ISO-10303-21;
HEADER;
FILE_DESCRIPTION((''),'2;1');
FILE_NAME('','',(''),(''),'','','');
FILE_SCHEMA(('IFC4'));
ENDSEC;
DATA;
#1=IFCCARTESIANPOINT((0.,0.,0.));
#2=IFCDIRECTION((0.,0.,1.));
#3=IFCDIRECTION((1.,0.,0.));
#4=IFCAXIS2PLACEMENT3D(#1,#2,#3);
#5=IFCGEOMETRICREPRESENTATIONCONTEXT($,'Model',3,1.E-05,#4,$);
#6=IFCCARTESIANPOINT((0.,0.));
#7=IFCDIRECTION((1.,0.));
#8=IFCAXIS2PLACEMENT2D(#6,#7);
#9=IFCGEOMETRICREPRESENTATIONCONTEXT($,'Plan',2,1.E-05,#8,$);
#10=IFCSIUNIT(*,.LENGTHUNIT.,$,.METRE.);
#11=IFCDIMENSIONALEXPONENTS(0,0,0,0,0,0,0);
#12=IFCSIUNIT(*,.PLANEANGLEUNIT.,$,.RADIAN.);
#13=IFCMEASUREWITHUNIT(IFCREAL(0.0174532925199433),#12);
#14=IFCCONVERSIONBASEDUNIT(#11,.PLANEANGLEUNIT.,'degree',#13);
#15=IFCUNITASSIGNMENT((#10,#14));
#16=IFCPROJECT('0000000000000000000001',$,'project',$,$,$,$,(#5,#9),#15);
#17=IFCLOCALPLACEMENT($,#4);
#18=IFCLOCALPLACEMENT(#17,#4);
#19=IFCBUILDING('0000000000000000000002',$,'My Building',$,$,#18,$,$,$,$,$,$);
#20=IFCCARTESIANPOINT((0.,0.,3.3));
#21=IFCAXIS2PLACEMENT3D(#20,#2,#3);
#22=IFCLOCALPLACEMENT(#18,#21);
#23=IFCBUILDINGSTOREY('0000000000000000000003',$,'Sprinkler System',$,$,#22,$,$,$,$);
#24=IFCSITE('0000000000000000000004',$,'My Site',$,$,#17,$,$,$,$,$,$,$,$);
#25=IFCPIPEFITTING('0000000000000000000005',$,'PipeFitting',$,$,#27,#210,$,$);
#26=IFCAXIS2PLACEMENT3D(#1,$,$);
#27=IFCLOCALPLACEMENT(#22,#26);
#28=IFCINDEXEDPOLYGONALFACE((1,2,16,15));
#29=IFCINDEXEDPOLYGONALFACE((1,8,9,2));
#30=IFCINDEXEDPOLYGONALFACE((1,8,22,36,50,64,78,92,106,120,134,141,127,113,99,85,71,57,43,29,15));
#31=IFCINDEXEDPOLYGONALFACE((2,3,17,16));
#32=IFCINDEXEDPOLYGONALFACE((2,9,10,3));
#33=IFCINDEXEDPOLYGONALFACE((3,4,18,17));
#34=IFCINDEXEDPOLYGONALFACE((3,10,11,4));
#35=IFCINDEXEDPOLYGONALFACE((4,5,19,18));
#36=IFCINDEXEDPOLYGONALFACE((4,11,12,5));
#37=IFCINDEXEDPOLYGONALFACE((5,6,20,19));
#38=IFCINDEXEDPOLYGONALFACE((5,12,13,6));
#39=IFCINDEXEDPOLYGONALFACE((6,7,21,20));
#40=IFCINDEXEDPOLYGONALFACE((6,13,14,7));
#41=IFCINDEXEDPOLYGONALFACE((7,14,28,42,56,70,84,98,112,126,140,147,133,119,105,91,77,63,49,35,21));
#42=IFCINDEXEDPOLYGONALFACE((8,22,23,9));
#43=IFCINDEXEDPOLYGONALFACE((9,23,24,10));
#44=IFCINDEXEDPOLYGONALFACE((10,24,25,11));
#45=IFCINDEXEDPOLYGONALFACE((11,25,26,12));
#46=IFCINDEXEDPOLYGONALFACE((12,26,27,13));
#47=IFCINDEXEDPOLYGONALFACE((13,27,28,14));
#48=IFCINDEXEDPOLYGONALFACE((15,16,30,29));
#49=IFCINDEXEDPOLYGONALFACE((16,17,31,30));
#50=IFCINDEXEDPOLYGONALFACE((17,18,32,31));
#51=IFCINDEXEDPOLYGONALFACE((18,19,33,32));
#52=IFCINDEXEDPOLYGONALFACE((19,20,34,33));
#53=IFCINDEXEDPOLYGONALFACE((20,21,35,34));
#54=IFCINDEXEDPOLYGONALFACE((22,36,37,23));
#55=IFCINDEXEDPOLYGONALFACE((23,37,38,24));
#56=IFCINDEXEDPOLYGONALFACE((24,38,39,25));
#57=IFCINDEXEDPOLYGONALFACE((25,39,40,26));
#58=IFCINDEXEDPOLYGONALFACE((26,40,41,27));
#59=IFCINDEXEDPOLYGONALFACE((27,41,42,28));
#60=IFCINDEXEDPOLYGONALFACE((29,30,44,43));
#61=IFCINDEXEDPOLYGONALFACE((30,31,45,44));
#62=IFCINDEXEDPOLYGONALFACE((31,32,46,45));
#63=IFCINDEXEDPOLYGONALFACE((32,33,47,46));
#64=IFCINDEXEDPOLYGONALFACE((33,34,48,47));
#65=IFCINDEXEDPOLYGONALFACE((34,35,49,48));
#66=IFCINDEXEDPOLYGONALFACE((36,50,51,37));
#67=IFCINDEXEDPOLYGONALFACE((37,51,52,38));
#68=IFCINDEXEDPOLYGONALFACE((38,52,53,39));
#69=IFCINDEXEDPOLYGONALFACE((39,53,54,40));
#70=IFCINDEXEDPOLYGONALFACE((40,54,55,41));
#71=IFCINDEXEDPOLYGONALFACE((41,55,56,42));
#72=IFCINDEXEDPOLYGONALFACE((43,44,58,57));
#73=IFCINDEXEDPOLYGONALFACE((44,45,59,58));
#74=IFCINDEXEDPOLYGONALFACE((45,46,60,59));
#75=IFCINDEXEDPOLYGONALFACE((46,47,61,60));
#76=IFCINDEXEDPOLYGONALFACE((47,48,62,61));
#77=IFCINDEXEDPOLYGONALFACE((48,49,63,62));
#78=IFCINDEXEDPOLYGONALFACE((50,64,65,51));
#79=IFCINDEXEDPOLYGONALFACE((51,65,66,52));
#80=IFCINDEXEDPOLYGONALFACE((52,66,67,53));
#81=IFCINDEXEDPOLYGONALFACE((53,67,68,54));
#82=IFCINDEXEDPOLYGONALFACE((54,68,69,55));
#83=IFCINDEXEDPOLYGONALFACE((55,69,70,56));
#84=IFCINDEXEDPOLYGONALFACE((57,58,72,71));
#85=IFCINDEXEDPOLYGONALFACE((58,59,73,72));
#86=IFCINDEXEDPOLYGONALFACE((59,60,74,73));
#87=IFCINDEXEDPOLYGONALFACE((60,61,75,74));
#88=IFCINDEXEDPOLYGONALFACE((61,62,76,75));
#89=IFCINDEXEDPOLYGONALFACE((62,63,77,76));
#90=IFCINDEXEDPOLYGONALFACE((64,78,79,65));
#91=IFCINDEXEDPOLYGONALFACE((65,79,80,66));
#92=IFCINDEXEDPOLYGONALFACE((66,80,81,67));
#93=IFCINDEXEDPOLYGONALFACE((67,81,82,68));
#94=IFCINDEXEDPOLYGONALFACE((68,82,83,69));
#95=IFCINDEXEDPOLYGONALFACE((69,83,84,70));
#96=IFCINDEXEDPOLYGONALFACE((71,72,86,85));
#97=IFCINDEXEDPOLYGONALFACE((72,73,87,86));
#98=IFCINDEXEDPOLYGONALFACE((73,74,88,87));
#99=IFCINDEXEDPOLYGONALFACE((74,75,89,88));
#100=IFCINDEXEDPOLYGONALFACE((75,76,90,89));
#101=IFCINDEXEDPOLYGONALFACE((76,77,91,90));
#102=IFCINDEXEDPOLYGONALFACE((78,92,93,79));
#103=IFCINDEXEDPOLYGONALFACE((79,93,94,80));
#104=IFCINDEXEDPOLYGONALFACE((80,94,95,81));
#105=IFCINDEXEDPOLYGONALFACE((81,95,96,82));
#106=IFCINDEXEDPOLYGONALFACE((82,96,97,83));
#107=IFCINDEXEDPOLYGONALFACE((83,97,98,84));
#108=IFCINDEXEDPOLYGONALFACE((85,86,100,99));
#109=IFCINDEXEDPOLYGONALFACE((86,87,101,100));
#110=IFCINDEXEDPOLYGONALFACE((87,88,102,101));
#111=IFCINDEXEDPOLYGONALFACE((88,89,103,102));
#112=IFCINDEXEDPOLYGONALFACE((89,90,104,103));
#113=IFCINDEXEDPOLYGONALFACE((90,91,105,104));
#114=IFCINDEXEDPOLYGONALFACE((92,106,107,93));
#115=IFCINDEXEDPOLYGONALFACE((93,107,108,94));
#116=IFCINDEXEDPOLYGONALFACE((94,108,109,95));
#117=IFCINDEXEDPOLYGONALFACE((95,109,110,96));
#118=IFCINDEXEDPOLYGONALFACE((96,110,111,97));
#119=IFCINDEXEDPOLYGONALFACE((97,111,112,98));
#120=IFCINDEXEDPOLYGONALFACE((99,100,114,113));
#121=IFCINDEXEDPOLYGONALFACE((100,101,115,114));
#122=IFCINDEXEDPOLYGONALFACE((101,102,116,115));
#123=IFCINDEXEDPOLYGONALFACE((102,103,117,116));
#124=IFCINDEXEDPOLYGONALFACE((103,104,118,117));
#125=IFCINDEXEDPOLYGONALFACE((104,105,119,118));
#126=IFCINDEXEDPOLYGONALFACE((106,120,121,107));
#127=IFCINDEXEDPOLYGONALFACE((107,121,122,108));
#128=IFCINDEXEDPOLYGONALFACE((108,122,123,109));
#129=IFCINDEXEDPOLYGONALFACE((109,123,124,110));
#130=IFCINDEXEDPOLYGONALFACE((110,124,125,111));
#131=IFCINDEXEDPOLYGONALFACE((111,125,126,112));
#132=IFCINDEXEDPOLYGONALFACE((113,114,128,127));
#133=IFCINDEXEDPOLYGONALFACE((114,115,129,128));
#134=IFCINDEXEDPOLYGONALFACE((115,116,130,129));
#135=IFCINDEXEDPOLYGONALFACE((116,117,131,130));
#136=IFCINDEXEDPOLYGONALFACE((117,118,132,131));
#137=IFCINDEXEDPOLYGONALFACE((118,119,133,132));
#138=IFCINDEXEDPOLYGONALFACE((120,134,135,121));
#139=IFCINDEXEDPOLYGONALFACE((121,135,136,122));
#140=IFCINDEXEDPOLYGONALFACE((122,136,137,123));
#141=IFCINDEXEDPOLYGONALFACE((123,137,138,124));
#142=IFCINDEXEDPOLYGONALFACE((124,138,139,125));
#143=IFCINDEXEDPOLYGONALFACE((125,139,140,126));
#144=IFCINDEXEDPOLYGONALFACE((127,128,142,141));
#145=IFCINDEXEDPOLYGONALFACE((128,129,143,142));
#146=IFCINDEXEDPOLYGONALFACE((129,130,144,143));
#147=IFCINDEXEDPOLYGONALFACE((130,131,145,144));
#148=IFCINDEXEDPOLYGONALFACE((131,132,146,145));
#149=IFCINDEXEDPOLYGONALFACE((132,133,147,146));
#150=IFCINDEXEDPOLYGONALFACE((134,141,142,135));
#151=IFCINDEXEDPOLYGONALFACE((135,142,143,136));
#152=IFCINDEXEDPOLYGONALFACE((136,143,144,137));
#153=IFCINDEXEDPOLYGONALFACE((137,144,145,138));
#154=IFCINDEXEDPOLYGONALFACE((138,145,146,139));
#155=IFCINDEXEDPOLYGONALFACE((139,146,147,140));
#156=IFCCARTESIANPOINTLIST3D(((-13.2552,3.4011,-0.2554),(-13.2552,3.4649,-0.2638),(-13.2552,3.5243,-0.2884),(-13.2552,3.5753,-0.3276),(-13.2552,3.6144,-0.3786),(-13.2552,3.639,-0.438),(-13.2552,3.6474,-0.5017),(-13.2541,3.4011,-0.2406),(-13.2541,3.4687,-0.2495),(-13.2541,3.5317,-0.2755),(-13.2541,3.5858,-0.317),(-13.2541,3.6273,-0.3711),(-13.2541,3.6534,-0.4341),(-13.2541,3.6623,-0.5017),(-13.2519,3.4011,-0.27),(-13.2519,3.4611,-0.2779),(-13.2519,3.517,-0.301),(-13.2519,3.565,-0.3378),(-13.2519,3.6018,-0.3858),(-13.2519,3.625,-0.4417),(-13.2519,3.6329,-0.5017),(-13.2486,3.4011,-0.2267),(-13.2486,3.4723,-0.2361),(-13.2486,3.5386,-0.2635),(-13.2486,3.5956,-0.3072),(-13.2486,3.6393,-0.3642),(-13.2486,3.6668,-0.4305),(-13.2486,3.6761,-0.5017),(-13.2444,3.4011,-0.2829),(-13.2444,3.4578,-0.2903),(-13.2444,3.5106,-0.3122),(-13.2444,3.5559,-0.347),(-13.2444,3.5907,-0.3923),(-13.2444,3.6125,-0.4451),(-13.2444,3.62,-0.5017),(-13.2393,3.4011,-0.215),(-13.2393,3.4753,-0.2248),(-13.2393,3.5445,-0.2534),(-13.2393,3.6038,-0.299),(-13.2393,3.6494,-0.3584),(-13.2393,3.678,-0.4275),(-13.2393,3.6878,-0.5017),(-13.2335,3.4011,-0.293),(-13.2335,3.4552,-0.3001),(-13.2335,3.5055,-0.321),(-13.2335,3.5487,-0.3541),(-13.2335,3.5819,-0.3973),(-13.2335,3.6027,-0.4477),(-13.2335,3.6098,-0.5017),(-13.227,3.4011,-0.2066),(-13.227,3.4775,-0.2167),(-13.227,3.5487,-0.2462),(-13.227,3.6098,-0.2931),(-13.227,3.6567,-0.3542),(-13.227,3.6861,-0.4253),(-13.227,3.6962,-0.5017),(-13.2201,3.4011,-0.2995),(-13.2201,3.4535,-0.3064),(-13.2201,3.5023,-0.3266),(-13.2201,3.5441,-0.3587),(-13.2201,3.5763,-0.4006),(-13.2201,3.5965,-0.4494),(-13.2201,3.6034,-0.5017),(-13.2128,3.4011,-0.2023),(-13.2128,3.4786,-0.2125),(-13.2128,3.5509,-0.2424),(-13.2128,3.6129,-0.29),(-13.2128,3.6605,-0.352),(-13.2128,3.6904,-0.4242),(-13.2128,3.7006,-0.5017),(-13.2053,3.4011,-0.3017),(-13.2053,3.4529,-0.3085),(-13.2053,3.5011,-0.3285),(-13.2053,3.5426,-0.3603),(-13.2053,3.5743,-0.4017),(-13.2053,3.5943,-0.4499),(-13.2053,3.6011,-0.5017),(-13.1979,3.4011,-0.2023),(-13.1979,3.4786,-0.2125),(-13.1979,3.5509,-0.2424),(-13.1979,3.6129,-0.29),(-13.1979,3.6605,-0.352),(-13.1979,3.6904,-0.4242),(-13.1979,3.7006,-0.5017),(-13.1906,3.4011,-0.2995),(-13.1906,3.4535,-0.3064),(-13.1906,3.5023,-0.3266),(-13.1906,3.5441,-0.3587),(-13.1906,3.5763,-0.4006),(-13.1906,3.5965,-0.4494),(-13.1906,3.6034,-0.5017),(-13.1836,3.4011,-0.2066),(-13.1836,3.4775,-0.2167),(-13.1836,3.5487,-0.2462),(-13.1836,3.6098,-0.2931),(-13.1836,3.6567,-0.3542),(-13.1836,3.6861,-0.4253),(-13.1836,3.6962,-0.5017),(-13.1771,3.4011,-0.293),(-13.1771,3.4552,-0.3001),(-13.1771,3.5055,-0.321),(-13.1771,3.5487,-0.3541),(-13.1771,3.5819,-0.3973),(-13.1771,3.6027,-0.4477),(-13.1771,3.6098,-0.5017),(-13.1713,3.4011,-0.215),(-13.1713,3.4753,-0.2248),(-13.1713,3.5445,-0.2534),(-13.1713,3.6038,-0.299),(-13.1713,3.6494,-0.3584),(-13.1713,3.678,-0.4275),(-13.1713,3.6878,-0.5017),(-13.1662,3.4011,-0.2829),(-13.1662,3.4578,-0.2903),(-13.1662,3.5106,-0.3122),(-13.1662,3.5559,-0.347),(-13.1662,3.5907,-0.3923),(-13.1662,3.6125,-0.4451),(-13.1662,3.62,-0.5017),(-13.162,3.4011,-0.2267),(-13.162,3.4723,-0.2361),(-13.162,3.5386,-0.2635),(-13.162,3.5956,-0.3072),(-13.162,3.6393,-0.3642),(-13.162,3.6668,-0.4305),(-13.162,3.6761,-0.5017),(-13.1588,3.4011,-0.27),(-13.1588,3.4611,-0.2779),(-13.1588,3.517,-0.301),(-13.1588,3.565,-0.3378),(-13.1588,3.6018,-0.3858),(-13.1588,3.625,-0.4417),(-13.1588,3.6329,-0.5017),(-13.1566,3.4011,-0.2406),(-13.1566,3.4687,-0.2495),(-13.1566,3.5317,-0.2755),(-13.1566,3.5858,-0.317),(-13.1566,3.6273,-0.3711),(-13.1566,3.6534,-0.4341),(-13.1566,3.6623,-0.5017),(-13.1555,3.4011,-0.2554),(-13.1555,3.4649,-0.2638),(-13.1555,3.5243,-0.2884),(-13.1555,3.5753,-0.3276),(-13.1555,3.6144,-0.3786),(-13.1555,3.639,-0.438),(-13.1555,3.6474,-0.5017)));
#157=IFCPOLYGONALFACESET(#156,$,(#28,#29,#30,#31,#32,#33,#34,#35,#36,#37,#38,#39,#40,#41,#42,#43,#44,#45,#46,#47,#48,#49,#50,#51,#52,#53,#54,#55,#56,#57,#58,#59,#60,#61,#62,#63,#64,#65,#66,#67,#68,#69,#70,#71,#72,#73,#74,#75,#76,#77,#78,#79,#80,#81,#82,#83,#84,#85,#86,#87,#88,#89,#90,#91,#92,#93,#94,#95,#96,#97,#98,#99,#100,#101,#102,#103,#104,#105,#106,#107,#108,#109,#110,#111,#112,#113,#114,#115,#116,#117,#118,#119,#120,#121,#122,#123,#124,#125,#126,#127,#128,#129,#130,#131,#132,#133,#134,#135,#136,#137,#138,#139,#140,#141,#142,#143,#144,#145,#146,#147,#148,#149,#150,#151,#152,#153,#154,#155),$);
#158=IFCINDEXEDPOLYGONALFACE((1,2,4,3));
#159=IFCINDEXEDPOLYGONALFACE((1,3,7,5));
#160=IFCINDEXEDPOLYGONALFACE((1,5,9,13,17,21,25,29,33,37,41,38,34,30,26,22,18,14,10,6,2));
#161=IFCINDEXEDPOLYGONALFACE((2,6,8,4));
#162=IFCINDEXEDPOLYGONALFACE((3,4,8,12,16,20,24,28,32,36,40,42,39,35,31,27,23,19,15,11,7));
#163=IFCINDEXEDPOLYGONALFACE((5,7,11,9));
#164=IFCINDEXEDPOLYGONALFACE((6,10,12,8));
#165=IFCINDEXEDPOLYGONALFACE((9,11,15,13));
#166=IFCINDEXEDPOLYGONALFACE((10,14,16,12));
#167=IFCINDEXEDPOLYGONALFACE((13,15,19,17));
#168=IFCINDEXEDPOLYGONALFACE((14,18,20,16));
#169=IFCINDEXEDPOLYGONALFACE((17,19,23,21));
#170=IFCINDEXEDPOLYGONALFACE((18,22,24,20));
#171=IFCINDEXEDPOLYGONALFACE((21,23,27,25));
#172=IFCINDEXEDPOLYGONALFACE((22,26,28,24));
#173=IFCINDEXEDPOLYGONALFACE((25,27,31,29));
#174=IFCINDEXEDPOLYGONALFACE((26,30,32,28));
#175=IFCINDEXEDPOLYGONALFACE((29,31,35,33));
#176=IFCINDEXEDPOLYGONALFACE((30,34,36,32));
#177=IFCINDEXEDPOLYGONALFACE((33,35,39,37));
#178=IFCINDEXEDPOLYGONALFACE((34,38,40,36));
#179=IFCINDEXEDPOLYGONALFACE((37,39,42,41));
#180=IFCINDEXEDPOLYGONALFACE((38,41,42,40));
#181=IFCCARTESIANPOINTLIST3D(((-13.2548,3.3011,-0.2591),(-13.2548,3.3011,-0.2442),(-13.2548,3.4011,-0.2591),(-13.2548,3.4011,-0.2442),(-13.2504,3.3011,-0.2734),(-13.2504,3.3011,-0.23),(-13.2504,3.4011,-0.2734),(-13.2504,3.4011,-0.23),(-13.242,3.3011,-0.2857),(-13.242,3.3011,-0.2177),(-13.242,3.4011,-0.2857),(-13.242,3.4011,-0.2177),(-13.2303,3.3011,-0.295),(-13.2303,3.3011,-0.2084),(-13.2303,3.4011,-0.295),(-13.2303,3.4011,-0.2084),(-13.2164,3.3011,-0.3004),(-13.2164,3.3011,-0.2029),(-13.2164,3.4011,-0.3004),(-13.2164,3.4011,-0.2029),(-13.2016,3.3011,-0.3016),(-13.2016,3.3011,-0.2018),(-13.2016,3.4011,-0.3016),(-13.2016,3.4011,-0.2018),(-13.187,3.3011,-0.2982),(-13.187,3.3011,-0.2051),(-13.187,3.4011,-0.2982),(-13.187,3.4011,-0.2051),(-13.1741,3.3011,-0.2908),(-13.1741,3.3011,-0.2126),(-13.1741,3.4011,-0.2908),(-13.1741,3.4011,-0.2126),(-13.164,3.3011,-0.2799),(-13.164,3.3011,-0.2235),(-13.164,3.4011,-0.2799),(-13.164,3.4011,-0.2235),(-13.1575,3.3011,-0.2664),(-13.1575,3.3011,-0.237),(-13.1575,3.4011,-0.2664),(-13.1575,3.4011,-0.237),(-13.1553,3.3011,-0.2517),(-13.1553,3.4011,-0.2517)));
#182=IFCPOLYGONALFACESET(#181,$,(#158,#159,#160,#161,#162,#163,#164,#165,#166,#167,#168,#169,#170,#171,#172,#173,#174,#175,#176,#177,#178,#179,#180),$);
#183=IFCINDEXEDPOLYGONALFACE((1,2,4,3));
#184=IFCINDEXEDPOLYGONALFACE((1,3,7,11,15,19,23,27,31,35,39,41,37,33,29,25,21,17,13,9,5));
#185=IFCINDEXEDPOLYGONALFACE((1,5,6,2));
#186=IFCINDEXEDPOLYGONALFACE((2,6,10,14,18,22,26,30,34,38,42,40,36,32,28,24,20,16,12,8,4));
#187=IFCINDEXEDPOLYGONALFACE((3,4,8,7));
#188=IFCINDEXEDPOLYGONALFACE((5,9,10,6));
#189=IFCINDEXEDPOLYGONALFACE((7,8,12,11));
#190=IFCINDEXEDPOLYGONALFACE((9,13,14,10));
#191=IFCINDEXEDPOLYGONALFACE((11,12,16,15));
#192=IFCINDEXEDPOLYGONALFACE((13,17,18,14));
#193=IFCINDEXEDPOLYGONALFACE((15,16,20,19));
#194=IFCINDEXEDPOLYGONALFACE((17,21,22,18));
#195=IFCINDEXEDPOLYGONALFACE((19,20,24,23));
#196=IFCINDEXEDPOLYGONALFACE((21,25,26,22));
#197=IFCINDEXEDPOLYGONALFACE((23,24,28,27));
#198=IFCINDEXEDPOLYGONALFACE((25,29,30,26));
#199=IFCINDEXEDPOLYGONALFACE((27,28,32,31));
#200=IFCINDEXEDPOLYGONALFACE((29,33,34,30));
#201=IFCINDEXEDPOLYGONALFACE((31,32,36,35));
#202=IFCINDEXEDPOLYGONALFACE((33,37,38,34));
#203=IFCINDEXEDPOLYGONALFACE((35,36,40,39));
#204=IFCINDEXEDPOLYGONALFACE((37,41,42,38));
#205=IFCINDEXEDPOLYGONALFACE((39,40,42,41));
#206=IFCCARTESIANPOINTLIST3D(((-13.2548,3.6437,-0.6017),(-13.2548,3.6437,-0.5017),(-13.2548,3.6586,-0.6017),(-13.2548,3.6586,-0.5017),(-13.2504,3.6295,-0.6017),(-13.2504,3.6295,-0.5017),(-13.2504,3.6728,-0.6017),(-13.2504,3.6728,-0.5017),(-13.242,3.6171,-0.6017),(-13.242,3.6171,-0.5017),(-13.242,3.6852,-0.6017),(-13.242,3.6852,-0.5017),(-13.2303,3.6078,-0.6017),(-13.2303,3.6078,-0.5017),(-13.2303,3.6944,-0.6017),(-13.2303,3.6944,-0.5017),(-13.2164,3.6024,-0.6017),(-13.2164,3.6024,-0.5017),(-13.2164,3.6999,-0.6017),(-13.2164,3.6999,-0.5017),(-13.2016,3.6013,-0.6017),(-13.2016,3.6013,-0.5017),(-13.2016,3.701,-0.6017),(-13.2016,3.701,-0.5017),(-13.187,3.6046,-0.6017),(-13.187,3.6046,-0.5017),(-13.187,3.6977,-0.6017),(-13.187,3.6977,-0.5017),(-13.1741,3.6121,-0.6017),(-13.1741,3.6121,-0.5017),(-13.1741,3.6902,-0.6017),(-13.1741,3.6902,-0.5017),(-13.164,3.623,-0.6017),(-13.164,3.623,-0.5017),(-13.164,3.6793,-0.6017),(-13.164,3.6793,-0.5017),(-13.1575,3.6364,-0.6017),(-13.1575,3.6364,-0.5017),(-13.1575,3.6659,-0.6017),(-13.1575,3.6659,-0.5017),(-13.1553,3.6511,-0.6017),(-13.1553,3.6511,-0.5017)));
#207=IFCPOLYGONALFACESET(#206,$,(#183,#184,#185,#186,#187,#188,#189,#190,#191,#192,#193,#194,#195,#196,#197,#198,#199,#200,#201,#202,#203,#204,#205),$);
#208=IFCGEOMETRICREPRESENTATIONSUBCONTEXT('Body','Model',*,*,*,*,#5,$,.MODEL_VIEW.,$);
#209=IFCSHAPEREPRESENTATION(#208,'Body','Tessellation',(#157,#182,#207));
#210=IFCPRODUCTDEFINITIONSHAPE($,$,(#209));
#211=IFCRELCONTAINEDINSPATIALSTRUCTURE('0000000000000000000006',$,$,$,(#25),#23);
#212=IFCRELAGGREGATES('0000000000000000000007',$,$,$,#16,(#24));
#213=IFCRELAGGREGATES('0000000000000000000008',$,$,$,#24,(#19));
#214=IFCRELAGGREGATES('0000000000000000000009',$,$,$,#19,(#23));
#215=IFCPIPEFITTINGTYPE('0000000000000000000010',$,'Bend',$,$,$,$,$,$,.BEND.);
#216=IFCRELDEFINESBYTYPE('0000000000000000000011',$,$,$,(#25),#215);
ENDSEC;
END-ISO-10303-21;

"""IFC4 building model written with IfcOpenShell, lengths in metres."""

from ifc_helpers import new_model, entity, si_unit, converted_unit, frame, origin_with_axes, origin_2d_with_axis, place, context, subcontext, project, spatial, circle, extrude, source, transform, mapped, type_object, type_shapes, element, save


model = new_model("IFC4")

# Units and contexts
model_context = context("Model", 3, precision=1e-05, world=origin_with_axes())
plan_context = context("Plan", 2, precision=1e-05, world=origin_2d_with_axis())
body_context = subcontext(model_context, "Body", "Model", "MODEL_VIEW")
ifc_project = project(units=[si_unit("LENGTHUNIT", "METRE"), converted_unit("PLANEANGLEUNIT", "degree", entity("IfcReal", 0.0174532925199433), si_unit("PLANEANGLEUNIT", "RADIAN"), dimensions=[0, 0, 0, 0, 0, 0, 0])], contexts=[model_context, plan_context])

# Site, building, storey
site_placement = place(None, origin_with_axes())
site = spatial("IfcSite", under=ifc_project, at=site_placement, Name="My Site")
building_placement = place(site_placement, origin_with_axes())
building = spatial("IfcBuilding", under=site, at=building_placement, Name="My Building")
storey_placement = place(building_placement, frame((0.0, 0.0, 3.3), z_axis=(0.0, 0.0, 1.0), x_axis=(1.0, 0.0, 0.0)))
storey = spatial("IfcBuildingStorey", under=building, at=storey_placement, Name="Sprinkler System")

# Pipe fitting
pipe_fitting_type_1 = type_object("IfcPipeFittingType", Name="Bend", PredefinedType="BEND")
shared_shape_1 = source(origin_with_axes(), body_context, "Body", "SolidModel", [
    entity("IfcSweptDiskSolid", entity("IfcIndexedPolyCurve", entity("IfcCartesianPointList3D", [[0.0, 0.0, -0.1], [0.0, -0.0732, -0.2768], [0.0, -0.25, -0.35]]), [entity("IfcArcIndex", [1, 2, 3])]), 0.05),
    extrude(circle(Radius=0.05), origin_with_axes(), (0.0, 0.0, -1.0), 0.1),
    extrude(circle(Radius=0.05), frame((0.0, -0.25, -0.35), z_axis=(0.0, -1.0, 0.000012), x_axis=(1.0, 0.0, 0.0)), (0.0, 0.0, 1.0), 0.1),
])
type_shapes(pipe_fitting_type_1, [shared_shape_1])
for number, where, z_axis, x_axis, name in (
    (1, (-13.2053, 3.3011, -0.2517), (-0.000001, -1.0, -0.000012), (1.0, -0.000001, 0.0), "PipeFitting"),
):
    element("IfcPipeFitting", number, at=place(storey_placement, frame(where, z_axis=z_axis, x_axis=x_axis)), inside=storey, type_object=pipe_fitting_type_1, Name=name, context=body_context, shape_type="MappedRepresentation", body=[
        mapped(shared_shape_1, transform((0.0, 0.0, 0.0), x_axis=(1.0, 0.0, 0.0), y_axis=(0.0, 1.0, 0.0), z_axis=(0.0, 0.0, 1.0), scale=1.0)),
    ])

save(model, "model.ifc")
